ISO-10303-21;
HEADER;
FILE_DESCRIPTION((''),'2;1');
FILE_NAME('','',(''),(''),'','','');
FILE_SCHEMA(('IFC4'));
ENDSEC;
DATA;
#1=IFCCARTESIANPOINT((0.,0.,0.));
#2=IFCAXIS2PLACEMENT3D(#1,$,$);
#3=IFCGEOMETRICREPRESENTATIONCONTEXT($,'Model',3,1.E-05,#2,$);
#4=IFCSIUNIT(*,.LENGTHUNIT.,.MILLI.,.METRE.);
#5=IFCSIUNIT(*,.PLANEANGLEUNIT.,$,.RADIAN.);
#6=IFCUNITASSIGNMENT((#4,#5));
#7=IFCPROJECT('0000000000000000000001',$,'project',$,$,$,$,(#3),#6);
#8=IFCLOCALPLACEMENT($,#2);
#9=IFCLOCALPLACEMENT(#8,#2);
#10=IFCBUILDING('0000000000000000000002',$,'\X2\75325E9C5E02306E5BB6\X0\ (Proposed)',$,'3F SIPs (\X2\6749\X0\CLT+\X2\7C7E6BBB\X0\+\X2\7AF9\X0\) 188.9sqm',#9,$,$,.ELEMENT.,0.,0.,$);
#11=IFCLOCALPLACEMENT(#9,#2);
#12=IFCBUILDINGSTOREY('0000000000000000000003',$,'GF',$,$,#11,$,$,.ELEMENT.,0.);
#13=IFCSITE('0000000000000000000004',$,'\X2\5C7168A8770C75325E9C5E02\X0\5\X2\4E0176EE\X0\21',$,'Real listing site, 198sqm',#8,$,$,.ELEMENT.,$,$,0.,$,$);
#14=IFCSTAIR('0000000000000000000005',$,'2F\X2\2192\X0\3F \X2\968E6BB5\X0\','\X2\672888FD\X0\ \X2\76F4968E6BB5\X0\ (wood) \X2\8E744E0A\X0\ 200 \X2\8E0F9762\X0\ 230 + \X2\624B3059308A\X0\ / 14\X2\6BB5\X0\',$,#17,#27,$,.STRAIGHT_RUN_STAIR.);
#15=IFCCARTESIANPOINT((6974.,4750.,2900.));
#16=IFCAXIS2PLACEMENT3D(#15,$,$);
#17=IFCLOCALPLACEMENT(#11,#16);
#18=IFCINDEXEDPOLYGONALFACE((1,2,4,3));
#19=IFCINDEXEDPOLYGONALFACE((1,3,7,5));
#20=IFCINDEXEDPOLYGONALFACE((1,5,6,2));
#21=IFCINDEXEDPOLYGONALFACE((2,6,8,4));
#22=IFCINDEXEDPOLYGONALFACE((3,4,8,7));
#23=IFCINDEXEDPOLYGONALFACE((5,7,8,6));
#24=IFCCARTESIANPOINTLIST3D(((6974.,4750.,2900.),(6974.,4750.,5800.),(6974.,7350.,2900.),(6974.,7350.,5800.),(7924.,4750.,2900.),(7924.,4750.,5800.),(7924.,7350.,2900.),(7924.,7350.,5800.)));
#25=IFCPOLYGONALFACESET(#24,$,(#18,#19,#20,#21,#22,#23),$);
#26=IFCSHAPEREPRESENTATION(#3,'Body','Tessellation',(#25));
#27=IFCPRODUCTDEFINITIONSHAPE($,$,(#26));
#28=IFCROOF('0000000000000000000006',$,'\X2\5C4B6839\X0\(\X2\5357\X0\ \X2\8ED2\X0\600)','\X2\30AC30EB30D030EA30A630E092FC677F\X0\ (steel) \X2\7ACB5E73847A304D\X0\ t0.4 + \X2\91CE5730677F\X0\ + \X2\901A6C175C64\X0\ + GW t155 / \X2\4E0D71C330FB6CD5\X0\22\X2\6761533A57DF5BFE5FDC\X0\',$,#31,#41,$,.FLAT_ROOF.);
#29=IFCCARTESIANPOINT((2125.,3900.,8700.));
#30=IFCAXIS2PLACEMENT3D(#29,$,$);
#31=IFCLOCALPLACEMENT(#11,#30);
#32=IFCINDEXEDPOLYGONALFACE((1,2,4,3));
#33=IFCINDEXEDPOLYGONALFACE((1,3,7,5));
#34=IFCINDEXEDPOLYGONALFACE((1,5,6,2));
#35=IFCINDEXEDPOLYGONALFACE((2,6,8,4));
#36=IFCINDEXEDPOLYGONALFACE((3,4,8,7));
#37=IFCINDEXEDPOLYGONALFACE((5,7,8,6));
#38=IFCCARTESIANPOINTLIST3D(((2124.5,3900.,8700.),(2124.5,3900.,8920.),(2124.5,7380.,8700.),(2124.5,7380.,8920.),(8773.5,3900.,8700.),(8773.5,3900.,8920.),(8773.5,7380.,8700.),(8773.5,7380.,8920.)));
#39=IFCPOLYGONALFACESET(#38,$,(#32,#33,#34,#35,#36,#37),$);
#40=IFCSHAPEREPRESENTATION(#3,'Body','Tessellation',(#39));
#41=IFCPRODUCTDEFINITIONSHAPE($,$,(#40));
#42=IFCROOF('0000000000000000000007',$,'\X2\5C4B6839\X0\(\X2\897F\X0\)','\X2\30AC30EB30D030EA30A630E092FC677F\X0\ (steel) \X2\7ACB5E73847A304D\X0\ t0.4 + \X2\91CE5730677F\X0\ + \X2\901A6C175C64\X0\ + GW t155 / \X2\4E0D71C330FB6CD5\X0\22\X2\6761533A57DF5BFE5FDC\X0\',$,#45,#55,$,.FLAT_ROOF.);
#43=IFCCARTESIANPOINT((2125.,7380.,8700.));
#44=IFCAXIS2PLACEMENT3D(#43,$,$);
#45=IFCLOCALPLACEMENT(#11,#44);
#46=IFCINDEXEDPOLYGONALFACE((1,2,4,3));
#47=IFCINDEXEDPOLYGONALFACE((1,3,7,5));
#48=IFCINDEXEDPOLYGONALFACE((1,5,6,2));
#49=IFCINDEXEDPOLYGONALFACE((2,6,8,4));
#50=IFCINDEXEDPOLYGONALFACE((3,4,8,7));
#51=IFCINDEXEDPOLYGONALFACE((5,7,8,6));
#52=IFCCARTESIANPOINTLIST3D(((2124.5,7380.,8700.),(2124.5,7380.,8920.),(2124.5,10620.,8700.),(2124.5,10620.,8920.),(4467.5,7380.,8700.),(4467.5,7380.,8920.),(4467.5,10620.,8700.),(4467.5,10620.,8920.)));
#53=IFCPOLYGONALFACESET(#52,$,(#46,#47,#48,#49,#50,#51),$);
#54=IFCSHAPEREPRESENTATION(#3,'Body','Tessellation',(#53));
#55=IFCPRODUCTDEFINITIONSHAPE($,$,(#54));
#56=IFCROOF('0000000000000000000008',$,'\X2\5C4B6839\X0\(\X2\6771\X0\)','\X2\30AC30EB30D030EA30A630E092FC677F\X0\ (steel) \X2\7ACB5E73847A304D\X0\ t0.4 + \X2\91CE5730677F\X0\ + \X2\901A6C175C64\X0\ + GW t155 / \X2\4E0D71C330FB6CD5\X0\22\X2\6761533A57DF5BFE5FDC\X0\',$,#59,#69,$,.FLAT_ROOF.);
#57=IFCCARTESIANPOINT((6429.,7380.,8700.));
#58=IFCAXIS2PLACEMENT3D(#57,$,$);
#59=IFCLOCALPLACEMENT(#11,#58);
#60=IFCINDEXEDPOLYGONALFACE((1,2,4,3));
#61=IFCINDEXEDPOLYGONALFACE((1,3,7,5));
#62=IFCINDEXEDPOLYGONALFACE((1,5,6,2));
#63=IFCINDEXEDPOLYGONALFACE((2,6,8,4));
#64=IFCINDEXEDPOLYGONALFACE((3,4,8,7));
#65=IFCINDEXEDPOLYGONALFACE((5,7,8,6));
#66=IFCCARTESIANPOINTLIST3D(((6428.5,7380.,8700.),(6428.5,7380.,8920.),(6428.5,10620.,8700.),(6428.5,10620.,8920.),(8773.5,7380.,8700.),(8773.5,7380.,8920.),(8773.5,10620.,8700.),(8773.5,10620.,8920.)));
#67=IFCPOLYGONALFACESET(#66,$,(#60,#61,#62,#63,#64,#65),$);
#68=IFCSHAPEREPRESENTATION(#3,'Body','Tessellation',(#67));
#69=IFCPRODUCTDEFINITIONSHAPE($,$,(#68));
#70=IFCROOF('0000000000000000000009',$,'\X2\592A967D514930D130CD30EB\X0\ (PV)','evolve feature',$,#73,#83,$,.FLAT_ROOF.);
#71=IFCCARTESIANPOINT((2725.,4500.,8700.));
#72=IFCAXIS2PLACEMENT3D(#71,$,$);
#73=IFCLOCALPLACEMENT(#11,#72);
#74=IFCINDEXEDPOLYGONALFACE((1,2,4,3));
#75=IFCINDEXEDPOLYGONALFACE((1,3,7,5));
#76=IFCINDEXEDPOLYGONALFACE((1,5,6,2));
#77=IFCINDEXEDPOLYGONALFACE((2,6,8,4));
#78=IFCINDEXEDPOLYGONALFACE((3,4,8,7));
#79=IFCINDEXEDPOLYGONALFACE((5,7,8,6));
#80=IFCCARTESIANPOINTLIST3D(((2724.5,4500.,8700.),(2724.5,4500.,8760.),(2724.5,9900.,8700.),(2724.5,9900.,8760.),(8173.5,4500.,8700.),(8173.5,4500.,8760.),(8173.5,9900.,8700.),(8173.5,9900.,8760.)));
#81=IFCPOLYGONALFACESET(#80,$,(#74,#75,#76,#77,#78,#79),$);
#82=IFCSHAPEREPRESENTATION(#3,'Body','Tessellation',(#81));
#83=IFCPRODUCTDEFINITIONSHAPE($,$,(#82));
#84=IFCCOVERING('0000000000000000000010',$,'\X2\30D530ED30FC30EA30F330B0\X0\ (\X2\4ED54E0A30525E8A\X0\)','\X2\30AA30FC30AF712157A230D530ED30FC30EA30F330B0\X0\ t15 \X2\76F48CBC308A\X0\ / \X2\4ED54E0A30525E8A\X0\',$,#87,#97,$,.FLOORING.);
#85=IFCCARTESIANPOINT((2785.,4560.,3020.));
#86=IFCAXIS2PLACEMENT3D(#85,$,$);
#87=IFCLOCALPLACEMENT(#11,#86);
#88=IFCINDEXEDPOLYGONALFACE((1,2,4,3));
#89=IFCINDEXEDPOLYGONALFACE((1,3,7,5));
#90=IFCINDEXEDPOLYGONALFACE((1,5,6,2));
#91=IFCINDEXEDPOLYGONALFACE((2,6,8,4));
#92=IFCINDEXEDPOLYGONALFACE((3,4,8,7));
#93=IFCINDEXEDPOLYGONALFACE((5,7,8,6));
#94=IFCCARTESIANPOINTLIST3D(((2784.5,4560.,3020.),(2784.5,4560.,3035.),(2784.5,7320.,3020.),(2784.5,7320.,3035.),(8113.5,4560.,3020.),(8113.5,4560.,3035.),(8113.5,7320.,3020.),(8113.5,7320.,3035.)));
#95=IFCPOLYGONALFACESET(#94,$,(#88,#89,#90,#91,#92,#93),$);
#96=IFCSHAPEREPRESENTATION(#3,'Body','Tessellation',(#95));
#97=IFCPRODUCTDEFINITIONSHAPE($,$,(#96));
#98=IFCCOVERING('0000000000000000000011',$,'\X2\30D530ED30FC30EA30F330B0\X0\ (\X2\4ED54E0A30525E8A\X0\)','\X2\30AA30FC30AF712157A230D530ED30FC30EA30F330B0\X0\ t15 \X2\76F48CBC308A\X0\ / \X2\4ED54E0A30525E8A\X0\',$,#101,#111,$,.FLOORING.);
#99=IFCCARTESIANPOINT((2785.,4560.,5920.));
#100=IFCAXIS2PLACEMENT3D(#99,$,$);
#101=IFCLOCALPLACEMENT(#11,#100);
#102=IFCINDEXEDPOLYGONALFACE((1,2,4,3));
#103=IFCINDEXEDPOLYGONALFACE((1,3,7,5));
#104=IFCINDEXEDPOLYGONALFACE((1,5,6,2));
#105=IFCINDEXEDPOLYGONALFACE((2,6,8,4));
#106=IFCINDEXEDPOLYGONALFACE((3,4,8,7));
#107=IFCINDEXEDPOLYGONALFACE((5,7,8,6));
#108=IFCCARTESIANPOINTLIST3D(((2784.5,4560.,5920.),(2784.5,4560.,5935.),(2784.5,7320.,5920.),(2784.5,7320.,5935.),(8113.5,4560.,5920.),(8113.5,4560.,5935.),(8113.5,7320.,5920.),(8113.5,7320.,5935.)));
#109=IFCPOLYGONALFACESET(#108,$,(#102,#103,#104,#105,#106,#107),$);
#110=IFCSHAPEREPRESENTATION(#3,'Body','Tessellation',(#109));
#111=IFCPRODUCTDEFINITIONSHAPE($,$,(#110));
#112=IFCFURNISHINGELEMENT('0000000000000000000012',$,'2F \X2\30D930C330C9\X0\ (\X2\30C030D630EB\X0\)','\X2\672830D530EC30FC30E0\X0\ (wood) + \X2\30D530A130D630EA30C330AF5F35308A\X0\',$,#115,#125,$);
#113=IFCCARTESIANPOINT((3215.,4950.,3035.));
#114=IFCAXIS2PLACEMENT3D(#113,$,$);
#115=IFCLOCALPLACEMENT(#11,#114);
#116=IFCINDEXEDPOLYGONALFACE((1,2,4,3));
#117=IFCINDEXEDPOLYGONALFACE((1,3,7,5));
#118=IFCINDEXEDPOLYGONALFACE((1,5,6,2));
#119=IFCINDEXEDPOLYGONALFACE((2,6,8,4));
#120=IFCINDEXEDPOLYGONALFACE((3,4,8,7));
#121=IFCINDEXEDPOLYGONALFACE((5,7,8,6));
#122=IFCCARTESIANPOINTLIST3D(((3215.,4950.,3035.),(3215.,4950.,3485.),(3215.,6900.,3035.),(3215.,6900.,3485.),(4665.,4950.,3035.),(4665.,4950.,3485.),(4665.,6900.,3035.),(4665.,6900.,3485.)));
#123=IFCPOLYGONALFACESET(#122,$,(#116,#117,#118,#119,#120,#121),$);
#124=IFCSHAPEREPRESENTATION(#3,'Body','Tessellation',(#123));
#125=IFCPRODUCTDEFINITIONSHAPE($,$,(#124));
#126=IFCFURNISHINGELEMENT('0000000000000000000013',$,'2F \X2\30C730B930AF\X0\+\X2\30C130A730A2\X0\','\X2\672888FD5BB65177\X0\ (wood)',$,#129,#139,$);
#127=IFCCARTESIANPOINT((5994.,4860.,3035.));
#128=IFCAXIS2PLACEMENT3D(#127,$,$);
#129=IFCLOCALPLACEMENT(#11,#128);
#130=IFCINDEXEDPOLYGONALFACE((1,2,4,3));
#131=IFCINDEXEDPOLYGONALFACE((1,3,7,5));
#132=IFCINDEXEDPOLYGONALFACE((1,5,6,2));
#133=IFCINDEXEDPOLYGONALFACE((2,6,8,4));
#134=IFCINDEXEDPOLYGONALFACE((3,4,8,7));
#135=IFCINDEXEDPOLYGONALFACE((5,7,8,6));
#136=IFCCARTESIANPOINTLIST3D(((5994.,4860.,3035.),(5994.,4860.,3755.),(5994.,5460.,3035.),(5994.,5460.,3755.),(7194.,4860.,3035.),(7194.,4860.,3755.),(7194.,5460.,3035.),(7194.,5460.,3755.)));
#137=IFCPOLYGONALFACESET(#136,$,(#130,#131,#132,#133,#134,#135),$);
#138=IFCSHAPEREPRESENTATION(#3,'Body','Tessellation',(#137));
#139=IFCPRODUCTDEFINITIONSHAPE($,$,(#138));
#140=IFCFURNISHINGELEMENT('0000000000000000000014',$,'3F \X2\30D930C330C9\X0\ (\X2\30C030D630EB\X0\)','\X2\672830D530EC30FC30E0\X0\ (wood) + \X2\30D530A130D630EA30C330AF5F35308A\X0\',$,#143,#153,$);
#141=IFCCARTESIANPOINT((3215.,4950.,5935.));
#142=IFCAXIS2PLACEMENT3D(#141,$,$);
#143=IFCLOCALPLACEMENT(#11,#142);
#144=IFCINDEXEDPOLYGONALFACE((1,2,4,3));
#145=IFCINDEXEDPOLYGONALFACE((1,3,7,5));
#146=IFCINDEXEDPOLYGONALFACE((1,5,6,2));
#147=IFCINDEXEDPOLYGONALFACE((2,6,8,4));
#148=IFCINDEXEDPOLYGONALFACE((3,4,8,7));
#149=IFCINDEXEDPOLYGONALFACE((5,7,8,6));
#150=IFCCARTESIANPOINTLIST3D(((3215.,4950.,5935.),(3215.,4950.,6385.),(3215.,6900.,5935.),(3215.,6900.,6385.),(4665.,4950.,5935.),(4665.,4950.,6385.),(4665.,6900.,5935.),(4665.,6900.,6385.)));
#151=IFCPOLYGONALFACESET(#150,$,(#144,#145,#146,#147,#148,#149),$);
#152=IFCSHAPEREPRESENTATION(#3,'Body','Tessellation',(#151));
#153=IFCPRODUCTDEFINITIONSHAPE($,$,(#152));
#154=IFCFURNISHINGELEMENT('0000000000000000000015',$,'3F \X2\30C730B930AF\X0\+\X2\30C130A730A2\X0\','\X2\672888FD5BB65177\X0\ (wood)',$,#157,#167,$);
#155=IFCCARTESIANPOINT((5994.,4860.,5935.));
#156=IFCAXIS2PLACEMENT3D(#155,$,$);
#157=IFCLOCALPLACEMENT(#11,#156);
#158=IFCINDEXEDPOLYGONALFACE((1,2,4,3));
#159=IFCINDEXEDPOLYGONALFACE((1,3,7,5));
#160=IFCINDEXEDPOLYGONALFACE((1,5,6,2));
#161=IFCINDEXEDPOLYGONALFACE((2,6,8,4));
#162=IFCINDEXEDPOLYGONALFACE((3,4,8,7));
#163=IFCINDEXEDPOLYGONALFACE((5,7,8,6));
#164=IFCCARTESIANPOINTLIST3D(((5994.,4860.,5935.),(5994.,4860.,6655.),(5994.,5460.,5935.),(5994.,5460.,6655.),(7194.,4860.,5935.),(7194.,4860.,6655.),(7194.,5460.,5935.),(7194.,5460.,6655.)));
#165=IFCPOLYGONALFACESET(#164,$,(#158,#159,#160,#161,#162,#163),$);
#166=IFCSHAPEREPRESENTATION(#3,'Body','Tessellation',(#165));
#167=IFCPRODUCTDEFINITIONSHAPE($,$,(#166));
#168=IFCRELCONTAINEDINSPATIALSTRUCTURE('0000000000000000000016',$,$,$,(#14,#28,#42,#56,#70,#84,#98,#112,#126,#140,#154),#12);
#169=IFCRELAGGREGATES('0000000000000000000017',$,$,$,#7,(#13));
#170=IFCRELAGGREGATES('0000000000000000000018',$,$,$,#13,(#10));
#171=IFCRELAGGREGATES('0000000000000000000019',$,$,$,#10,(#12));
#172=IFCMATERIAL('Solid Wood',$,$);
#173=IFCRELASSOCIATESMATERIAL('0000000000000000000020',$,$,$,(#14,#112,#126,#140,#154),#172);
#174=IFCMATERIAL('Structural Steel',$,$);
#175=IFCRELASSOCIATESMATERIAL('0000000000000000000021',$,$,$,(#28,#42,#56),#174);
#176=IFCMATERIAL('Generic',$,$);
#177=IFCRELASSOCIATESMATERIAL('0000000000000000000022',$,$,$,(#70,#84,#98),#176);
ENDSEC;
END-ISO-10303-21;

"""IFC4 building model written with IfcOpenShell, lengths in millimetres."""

from ifc_helpers import new_model, si_unit, frame, frame_2d, origin, place, context, project, spatial, rectangle, extrude, material, element, save


model = new_model("IFC4")

# Units and contexts
model_context = context("Model", 3, precision=1e-05, world=origin())
ifc_project = project(units=[si_unit("LENGTHUNIT", "METRE", prefix="MILLI"), si_unit("PLANEANGLEUNIT", "RADIAN")], contexts=[model_context])

# Site, building, storey
site_placement = place(None, origin())
site = spatial("IfcSite", under=ifc_project, at=site_placement, Name="山梨県甲府市5丁目21", ObjectType="Real listing site, 198sqm", CompositionType="ELEMENT", RefElevation=0.0)
building_placement = place(site_placement, origin())
building = spatial("IfcBuilding", under=site, at=building_placement, Name="甲府市の家 (Proposed)", ObjectType="3F SIPs (杉CLT+籾殻+竹) 188.9sqm", CompositionType="ELEMENT", ElevationOfRefHeight=0.0, ElevationOfTerrain=0.0)
storey_placement = place(building_placement, origin())
storey = spatial("IfcBuildingStorey", under=building, at=storey_placement, Name="GF", CompositionType="ELEMENT", Elevation=0.0)

# Shared definitions
ifc_material_1 = material(Name="Solid Wood")

# Stair
stair_placement = place(storey_placement, frame((6974.0, 4750.0, 2900.0)))
element("IfcStair", 1, at=stair_placement, inside=storey, material=ifc_material_1, Name="2F→3F 階段", Description="木製 直階段 (wood) 蹴上 200 踏面 230 + 手すり / 14段", PredefinedType="STRAIGHT_RUN_STAIR", context=model_context, shape_type="SweptSolid", body=[
    extrude(rectangle(XDim=950.0, YDim=2600.0, at=frame_2d((475.0, 1300.0))), frame((6974.0, 4750.0, 2900.0)), (0.0, 0.0, 1.0), 2900.0),
])

# Roofs
ifc_material_2 = material(Name="Structural Steel")
roof_1_placement = place(storey_placement, frame((2125.0, 3900.0, 8700.0)))
element("IfcRoof", 2, at=roof_1_placement, inside=storey, material=ifc_material_2, Name="屋根(南 軒600)", Description="ガルバリウム鋼板 (steel) 立平葺き t0.4 + 野地板 + 通気層 + GW t155 / 不燃・法22条区域対応", PredefinedType="FLAT_ROOF", context=model_context, shape_type="SweptSolid", body=[
    extrude(rectangle(XDim=6649.0, YDim=3480.0, at=frame_2d((3324.0, 1740.0))), frame((2125.0, 3900.0, 8700.0)), (0.0, 0.0, 1.0), 220.0),
])
roof_2_placement = place(storey_placement, frame((2125.0, 7380.0, 8700.0)))
element("IfcRoof", 3, at=roof_2_placement, inside=storey, material=ifc_material_2, Name="屋根(西)", Description="ガルバリウム鋼板 (steel) 立平葺き t0.4 + 野地板 + 通気層 + GW t155 / 不燃・法22条区域対応", PredefinedType="FLAT_ROOF", context=model_context, shape_type="SweptSolid", body=[
    extrude(rectangle(XDim=2343.0, YDim=3240.0, at=frame_2d((1171.0, 1620.0))), frame((2125.0, 7380.0, 8700.0)), (0.0, 0.0, 1.0), 220.0),
])
roof_3_placement = place(storey_placement, frame((6429.0, 7380.0, 8700.0)))
element("IfcRoof", 4, at=roof_3_placement, inside=storey, material=ifc_material_2, Name="屋根(東)", Description="ガルバリウム鋼板 (steel) 立平葺き t0.4 + 野地板 + 通気層 + GW t155 / 不燃・法22条区域対応", PredefinedType="FLAT_ROOF", context=model_context, shape_type="SweptSolid", body=[
    extrude(rectangle(XDim=2345.0, YDim=3240.0, at=frame_2d((1172.0, 1620.0))), frame((6429.0, 7380.0, 8700.0)), (0.0, 0.0, 1.0), 220.0),
])
ifc_material_3 = material(Name="Generic")
roof_4_placement = place(storey_placement, frame((2725.0, 4500.0, 8700.0)))
element("IfcRoof", 5, at=roof_4_placement, inside=storey, material=ifc_material_3, Name="太陽光パネル (PV)", Description="evolve feature", PredefinedType="FLAT_ROOF", context=model_context, shape_type="SweptSolid", body=[
    extrude(rectangle(XDim=5449.0, YDim=5400.0, at=frame_2d((2724.0, 2700.0))), frame((2725.0, 4500.0, 8700.0)), (0.0, 0.0, 1.0), 60.0),
])

# Coverings
covering_1_placement = place(storey_placement, frame((2785.0, 4560.0, 3020.0)))
element("IfcCovering", 6, at=covering_1_placement, inside=storey, material=ifc_material_3, Name="フローリング (仕上げ床)", Description="オーク無垢フローリング t15 直貼り / 仕上げ床", PredefinedType="FLOORING", context=model_context, shape_type="SweptSolid", body=[
    extrude(rectangle(XDim=5329.0, YDim=2760.0, at=frame_2d((2664.0, 1380.0))), frame((2785.0, 4560.0, 3020.0)), (0.0, 0.0, 1.0), 15.0),
])
covering_2_placement = place(storey_placement, frame((2785.0, 4560.0, 5920.0)))
element("IfcCovering", 7, at=covering_2_placement, inside=storey, material=ifc_material_3, Name="フローリング (仕上げ床)", Description="オーク無垢フローリング t15 直貼り / 仕上げ床", PredefinedType="FLOORING", context=model_context, shape_type="SweptSolid", body=[
    extrude(rectangle(XDim=5329.0, YDim=2760.0, at=frame_2d((2664.0, 1380.0))), frame((2785.0, 4560.0, 5920.0)), (0.0, 0.0, 1.0), 15.0),
])

# Furnishing elements
furnishing_1_placement = place(storey_placement, frame((3215.0, 4950.0, 3035.0)))
element("IfcFurnishingElement", 8, at=furnishing_1_placement, inside=storey, material=ifc_material_1, Name="2F ベッド (ダブル)", Description="木フレーム (wood) + ファブリック張り", context=model_context, shape_type="SweptSolid", body=[
    extrude(rectangle(XDim=1450.0, YDim=1950.0, at=frame_2d((725.0, 975.0))), frame((3215.0, 4950.0, 3035.0)), (0.0, 0.0, 1.0), 450.0),
])
furnishing_2_placement = place(storey_placement, frame((5994.0, 4860.0, 3035.0)))
element("IfcFurnishingElement", 9, at=furnishing_2_placement, inside=storey, material=ifc_material_1, Name="2F デスク+チェア", Description="木製家具 (wood)", context=model_context, shape_type="SweptSolid", body=[
    extrude(rectangle(XDim=1200.0, YDim=600.0, at=frame_2d((600.0, 300.0))), frame((5994.0, 4860.0, 3035.0)), (0.0, 0.0, 1.0), 720.0),
])
furnishing_3_placement = place(storey_placement, frame((3215.0, 4950.0, 5935.0)))
element("IfcFurnishingElement", 10, at=furnishing_3_placement, inside=storey, material=ifc_material_1, Name="3F ベッド (ダブル)", Description="木フレーム (wood) + ファブリック張り", context=model_context, shape_type="SweptSolid", body=[
    extrude(rectangle(XDim=1450.0, YDim=1950.0, at=frame_2d((725.0, 975.0))), frame((3215.0, 4950.0, 5935.0)), (0.0, 0.0, 1.0), 450.0),
])
furnishing_4_placement = place(storey_placement, frame((5994.0, 4860.0, 5935.0)))
element("IfcFurnishingElement", 11, at=furnishing_4_placement, inside=storey, material=ifc_material_1, Name="3F デスク+チェア", Description="木製家具 (wood)", context=model_context, shape_type="SweptSolid", body=[
    extrude(rectangle(XDim=1200.0, YDim=600.0, at=frame_2d((600.0, 300.0))), frame((5994.0, 4860.0, 5935.0)), (0.0, 0.0, 1.0), 720.0),
])

save(model, "model.ifc")
